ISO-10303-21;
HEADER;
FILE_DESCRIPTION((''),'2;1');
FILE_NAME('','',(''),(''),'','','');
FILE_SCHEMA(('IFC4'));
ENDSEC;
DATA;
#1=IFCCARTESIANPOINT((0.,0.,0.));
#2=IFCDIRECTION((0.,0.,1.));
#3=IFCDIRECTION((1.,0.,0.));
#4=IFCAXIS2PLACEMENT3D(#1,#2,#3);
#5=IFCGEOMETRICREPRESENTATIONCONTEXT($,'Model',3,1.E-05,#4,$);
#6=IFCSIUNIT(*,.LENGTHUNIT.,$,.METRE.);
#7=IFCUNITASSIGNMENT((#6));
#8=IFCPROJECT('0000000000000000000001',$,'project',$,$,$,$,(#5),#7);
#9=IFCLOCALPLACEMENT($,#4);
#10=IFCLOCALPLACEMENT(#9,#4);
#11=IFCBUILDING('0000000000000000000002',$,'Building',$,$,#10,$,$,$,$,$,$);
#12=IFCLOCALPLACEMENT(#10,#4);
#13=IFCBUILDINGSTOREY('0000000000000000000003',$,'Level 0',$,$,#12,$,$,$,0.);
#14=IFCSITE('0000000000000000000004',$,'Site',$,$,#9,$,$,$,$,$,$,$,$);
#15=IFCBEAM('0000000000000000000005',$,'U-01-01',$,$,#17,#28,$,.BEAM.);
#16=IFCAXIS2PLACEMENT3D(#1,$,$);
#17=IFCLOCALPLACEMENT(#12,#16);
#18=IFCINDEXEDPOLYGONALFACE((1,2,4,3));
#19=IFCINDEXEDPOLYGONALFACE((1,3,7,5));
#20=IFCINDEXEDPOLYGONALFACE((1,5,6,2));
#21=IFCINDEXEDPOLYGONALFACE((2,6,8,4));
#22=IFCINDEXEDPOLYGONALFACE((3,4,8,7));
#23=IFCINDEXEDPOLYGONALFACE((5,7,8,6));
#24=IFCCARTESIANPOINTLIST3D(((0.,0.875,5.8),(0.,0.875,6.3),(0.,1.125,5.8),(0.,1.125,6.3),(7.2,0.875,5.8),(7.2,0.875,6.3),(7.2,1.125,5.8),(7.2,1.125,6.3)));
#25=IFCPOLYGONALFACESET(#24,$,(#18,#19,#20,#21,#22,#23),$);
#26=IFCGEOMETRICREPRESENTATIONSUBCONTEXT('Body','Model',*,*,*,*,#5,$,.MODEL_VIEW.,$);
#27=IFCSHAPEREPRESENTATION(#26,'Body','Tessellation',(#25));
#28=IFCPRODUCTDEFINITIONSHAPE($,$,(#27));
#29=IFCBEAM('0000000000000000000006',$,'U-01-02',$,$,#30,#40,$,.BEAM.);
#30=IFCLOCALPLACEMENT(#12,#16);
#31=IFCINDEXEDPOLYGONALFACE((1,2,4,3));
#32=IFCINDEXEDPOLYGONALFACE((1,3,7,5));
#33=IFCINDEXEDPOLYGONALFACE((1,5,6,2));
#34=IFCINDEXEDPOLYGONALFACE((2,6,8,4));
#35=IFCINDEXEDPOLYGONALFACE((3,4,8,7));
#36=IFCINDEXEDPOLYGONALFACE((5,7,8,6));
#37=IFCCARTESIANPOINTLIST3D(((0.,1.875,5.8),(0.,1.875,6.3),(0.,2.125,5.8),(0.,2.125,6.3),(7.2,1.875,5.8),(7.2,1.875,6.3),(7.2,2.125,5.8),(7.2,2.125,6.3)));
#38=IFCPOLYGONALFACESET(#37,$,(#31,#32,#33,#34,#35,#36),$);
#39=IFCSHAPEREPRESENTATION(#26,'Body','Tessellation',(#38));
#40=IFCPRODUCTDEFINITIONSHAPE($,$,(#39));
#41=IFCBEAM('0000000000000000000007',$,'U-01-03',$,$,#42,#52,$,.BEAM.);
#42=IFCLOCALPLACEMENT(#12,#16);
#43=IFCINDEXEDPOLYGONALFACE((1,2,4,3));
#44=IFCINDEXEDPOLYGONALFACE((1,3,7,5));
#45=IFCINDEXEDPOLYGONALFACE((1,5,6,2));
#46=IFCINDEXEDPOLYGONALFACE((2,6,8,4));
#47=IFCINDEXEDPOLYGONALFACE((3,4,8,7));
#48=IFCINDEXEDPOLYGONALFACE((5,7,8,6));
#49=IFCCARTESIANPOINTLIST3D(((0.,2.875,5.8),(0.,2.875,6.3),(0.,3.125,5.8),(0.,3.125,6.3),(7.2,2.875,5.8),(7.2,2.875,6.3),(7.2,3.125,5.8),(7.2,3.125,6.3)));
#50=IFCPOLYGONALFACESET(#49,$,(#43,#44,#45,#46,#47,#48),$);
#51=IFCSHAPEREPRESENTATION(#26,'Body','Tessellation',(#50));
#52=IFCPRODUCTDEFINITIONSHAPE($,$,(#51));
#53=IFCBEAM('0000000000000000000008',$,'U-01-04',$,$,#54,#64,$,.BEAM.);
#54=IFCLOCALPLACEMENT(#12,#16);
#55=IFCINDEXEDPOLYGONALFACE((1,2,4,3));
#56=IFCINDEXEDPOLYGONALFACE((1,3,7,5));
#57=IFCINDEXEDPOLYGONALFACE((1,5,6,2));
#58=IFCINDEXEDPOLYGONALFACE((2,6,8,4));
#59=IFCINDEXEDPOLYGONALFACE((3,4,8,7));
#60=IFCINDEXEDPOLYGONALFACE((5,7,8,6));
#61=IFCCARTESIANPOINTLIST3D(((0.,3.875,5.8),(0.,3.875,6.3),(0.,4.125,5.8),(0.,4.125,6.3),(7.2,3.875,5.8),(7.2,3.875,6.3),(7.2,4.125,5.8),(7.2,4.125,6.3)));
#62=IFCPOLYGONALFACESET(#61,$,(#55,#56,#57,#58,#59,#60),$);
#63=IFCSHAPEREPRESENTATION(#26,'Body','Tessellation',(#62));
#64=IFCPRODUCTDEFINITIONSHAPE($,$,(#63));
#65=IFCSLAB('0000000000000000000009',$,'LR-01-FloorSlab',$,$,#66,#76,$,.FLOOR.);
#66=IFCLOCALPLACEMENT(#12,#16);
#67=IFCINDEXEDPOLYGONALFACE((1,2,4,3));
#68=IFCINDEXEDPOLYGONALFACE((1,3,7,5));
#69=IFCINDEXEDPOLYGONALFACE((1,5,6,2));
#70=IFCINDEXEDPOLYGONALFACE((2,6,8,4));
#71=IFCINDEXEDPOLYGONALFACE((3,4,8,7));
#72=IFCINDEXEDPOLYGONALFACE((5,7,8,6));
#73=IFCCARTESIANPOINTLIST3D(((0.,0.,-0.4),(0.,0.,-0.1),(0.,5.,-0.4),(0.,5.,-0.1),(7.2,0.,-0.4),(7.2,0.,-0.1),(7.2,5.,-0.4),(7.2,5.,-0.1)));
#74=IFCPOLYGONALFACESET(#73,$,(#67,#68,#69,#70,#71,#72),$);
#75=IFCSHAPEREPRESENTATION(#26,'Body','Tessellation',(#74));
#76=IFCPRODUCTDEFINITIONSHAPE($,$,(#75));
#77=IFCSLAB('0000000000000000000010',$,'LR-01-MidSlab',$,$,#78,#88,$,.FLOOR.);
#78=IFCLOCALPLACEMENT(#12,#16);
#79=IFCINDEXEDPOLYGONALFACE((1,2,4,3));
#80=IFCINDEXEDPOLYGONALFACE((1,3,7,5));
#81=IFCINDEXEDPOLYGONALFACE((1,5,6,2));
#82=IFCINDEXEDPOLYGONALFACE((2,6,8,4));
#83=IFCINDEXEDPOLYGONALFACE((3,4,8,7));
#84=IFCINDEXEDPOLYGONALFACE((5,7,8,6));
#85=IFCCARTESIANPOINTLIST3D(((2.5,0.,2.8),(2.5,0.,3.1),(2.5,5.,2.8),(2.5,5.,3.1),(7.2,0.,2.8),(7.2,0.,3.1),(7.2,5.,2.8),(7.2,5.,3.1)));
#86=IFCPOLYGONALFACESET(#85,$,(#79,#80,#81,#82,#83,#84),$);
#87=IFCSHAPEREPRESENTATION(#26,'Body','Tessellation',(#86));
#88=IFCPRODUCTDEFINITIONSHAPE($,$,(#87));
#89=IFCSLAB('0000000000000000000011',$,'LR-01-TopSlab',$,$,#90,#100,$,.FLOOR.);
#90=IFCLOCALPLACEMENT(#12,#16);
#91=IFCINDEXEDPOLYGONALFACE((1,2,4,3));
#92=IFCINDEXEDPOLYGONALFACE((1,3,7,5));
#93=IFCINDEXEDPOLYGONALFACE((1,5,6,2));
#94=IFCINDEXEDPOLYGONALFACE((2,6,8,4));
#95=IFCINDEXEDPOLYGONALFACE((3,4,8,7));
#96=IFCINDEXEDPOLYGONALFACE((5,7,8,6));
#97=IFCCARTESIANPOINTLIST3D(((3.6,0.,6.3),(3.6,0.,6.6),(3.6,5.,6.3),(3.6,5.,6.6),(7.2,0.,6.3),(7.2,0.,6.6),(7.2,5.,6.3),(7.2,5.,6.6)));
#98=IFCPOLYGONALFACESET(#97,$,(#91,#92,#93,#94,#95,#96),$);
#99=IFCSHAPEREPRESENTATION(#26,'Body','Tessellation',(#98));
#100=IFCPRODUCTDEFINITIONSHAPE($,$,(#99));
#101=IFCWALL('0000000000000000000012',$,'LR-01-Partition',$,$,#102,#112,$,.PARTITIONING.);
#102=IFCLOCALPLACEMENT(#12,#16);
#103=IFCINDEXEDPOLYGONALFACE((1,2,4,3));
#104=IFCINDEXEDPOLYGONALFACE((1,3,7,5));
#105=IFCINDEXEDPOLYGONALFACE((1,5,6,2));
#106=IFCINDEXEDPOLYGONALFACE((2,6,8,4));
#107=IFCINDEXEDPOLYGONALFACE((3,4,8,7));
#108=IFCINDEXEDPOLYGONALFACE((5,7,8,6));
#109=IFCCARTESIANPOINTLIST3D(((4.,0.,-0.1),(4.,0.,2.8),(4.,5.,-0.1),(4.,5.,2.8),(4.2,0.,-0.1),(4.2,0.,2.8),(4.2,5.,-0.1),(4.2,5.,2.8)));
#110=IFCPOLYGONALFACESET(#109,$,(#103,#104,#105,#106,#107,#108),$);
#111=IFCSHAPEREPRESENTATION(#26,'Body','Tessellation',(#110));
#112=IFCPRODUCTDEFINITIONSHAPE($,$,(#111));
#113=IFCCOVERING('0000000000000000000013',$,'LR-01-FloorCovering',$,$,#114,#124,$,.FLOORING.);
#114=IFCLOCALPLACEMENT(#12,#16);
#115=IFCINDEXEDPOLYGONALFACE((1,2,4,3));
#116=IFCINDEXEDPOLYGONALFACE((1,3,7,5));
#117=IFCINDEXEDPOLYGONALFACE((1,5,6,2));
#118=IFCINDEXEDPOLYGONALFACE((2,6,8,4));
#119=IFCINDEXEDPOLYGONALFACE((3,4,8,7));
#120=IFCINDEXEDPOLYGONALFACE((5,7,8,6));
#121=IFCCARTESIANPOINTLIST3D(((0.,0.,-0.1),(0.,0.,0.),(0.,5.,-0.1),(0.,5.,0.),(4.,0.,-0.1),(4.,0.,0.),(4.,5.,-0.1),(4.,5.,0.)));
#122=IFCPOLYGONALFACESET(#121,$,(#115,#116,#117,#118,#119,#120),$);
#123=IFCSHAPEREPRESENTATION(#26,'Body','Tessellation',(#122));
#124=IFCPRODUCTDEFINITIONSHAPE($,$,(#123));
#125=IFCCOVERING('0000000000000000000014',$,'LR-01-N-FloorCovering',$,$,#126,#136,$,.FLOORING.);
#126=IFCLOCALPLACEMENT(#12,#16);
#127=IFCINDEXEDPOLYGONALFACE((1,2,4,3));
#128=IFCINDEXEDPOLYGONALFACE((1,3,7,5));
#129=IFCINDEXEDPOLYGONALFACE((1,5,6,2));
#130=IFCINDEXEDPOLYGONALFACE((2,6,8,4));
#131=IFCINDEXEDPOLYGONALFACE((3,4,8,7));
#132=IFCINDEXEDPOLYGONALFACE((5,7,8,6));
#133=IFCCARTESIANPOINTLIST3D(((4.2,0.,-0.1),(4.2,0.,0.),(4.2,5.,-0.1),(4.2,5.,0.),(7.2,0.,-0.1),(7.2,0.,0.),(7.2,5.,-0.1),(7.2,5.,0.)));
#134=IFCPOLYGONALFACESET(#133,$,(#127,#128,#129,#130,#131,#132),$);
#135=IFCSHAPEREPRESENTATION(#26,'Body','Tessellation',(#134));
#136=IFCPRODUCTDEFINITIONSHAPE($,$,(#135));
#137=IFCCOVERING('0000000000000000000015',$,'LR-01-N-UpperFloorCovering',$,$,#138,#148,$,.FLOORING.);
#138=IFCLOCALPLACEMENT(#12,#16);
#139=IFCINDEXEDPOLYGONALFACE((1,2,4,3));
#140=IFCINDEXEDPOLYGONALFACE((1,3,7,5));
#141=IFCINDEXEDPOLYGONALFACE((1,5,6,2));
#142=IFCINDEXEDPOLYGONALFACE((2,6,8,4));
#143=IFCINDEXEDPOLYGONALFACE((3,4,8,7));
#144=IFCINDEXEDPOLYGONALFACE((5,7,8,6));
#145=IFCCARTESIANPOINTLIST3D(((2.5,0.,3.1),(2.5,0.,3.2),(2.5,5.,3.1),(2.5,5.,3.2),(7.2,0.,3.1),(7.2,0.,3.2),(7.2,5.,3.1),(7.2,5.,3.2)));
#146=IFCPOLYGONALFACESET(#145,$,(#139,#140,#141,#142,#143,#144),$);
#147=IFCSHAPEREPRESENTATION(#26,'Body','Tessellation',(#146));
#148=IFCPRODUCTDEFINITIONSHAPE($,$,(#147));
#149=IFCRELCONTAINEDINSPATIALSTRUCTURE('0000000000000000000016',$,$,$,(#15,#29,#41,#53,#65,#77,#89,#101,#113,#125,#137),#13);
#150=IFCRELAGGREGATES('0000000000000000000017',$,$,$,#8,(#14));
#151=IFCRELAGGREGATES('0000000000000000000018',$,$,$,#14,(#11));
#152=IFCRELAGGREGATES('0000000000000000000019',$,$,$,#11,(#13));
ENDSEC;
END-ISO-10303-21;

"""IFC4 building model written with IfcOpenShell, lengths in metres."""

from ifc_helpers import new_model, si_unit, frame, origin_with_axes, place, context, subcontext, project, spatial, polyline, outline, extrude, element, save


model = new_model("IFC4")

# Units and contexts
model_context = context("Model", 3, precision=1e-05, world=origin_with_axes())
body_context = subcontext(model_context, "Body", "Model", "MODEL_VIEW")
ifc_project = project(units=[si_unit("LENGTHUNIT", "METRE")], contexts=[model_context])

# Site, building, storey
site_placement = place(None, origin_with_axes())
site = spatial("IfcSite", under=ifc_project, at=site_placement, Name="Site")
building_placement = place(site_placement, origin_with_axes())
building = spatial("IfcBuilding", under=site, at=building_placement, Name="Building")
storey_placement = place(building_placement, origin_with_axes())
storey = spatial("IfcBuildingStorey", under=building, at=storey_placement, Name="Level 0", Elevation=0.0)

# Beams
beam_1_placement = place(storey_placement, frame((0.0, 0.0, 5.8), z_axis=(0.0, 0.0, 1.0), x_axis=(1.0, 0.0, 0.0)))
element("IfcBeam", 1, at=beam_1_placement, inside=storey, Name="U-01-01", PredefinedType="BEAM", context=body_context, shape_type="SweptSolid", body=[
    extrude(outline(polyline([(0.0, 0.875, 0.0), (7.2, 0.875, 0.0), (7.2, 1.125, 0.0), (0.0, 1.125, 0.0), (0.0, 0.875, 0.0)])), origin_with_axes(), (0.0, 0.0, 1.0), 0.5),
])
beam_2_placement = place(storey_placement, frame((0.0, 0.0, 5.8), z_axis=(0.0, 0.0, 1.0), x_axis=(1.0, 0.0, 0.0)))
element("IfcBeam", 2, at=beam_2_placement, inside=storey, Name="U-01-02", PredefinedType="BEAM", context=body_context, shape_type="SweptSolid", body=[
    extrude(outline(polyline([(0.0, 1.875, 0.0), (7.2, 1.875, 0.0), (7.2, 2.125, 0.0), (0.0, 2.125, 0.0), (0.0, 1.875, 0.0)])), origin_with_axes(), (0.0, 0.0, 1.0), 0.5),
])
beam_3_placement = place(storey_placement, frame((0.0, 0.0, 5.8), z_axis=(0.0, 0.0, 1.0), x_axis=(1.0, 0.0, 0.0)))
element("IfcBeam", 3, at=beam_3_placement, inside=storey, Name="U-01-03", PredefinedType="BEAM", context=body_context, shape_type="SweptSolid", body=[
    extrude(outline(polyline([(0.0, 2.875, 0.0), (7.2, 2.875, 0.0), (7.2, 3.125, 0.0), (0.0, 3.125, 0.0), (0.0, 2.875, 0.0)])), origin_with_axes(), (0.0, 0.0, 1.0), 0.5),
])
beam_4_placement = place(storey_placement, frame((0.0, 0.0, 5.8), z_axis=(0.0, 0.0, 1.0), x_axis=(1.0, 0.0, 0.0)))
element("IfcBeam", 4, at=beam_4_placement, inside=storey, Name="U-01-04", PredefinedType="BEAM", context=body_context, shape_type="SweptSolid", body=[
    extrude(outline(polyline([(0.0, 3.875, 0.0), (7.2, 3.875, 0.0), (7.2, 4.125, 0.0), (0.0, 4.125, 0.0), (0.0, 3.875, 0.0)])), origin_with_axes(), (0.0, 0.0, 1.0), 0.5),
])

# Slabs
slab_1_placement = place(storey_placement, frame((0.0, 0.0, -0.4), z_axis=(0.0, 0.0, 1.0), x_axis=(1.0, 0.0, 0.0)))
element("IfcSlab", 5, at=slab_1_placement, inside=storey, Name="LR-01-FloorSlab", PredefinedType="FLOOR", context=body_context, shape_type="SweptSolid", body=[
    extrude(outline(polyline([(0.0, 0.0, 0.0), (7.2, 0.0, 0.0), (7.2, 5.0, 0.0), (0.0, 5.0, 0.0), (0.0, 0.0, 0.0)])), origin_with_axes(), (0.0, 0.0, 1.0), 0.3),
])
slab_2_placement = place(storey_placement, frame((0.0, 0.0, 2.8), z_axis=(0.0, 0.0, 1.0), x_axis=(1.0, 0.0, 0.0)))
element("IfcSlab", 6, at=slab_2_placement, inside=storey, Name="LR-01-MidSlab", PredefinedType="FLOOR", context=body_context, shape_type="SweptSolid", body=[
    extrude(outline(polyline([(2.5, 0.0, 0.0), (7.2, 0.0, 0.0), (7.2, 5.0, 0.0), (2.5, 5.0, 0.0), (2.5, 0.0, 0.0)])), origin_with_axes(), (0.0, 0.0, 1.0), 0.3),
])
slab_3_placement = place(storey_placement, frame((0.0, 0.0, 6.3), z_axis=(0.0, 0.0, 1.0), x_axis=(1.0, 0.0, 0.0)))
element("IfcSlab", 7, at=slab_3_placement, inside=storey, Name="LR-01-TopSlab", PredefinedType="FLOOR", context=body_context, shape_type="SweptSolid", body=[
    extrude(outline(polyline([(3.6, 0.0, 0.0), (7.2, 0.0, 0.0), (7.2, 5.0, 0.0), (3.6, 5.0, 0.0), (3.6, 0.0, 0.0)])), origin_with_axes(), (0.0, 0.0, 1.0), 0.3),
])

# Wall
wall_placement = place(storey_placement, frame((4.2, 0.0, -0.1), z_axis=(0.0, 0.0, 1.0), x_axis=(0.0, 1.0, 0.0)))
element("IfcWall", 8, at=wall_placement, inside=storey, Name="LR-01-Partition", PredefinedType="PARTITIONING", context=body_context, shape_type="SweptSolid", body=[
    extrude(outline(polyline([(0.0, 0.0, 0.0), (5.0, 0.0, 0.0), (5.0, 0.2, 0.0), (0.0, 0.2, 0.0), (0.0, 0.0, 0.0)])), origin_with_axes(), (0.0, 0.0, 1.0), 2.9),
])

# Coverings
covering_1_placement = place(storey_placement, frame((0.0, 0.0, -0.1), z_axis=(0.0, 0.0, 1.0), x_axis=(1.0, 0.0, 0.0)))
element("IfcCovering", 9, at=covering_1_placement, inside=storey, Name="LR-01-FloorCovering", PredefinedType="FLOORING", context=body_context, shape_type="SweptSolid", body=[
    extrude(outline(polyline([(0.0, 0.0, 0.0), (4.0, 0.0, 0.0), (4.0, 5.0, 0.0), (0.0, 5.0, 0.0), (0.0, 0.0, 0.0)])), origin_with_axes(), (0.0, 0.0, 1.0), 0.1),
])
covering_2_placement = place(storey_placement, frame((0.0, 0.0, -0.1), z_axis=(0.0, 0.0, 1.0), x_axis=(1.0, 0.0, 0.0)))
element("IfcCovering", 10, at=covering_2_placement, inside=storey, Name="LR-01-N-FloorCovering", PredefinedType="FLOORING", context=body_context, shape_type="SweptSolid", body=[
    extrude(outline(polyline([(4.2, 0.0, 0.0), (7.2, 0.0, 0.0), (7.2, 5.0, 0.0), (4.2, 5.0, 0.0), (4.2, 0.0, 0.0)])), origin_with_axes(), (0.0, 0.0, 1.0), 0.1),
])
covering_3_placement = place(storey_placement, frame((0.0, 0.0, 3.1), z_axis=(0.0, 0.0, 1.0), x_axis=(1.0, 0.0, 0.0)))
element("IfcCovering", 11, at=covering_3_placement, inside=storey, Name="LR-01-N-UpperFloorCovering", PredefinedType="FLOORING", context=body_context, shape_type="SweptSolid", body=[
    extrude(outline(polyline([(2.5, 0.0, 0.0), (7.2, 0.0, 0.0), (7.2, 5.0, 0.0), (2.5, 5.0, 0.0), (2.5, 0.0, 0.0)])), origin_with_axes(), (0.0, 0.0, 1.0), 0.1),
])

save(model, "model.ifc")
